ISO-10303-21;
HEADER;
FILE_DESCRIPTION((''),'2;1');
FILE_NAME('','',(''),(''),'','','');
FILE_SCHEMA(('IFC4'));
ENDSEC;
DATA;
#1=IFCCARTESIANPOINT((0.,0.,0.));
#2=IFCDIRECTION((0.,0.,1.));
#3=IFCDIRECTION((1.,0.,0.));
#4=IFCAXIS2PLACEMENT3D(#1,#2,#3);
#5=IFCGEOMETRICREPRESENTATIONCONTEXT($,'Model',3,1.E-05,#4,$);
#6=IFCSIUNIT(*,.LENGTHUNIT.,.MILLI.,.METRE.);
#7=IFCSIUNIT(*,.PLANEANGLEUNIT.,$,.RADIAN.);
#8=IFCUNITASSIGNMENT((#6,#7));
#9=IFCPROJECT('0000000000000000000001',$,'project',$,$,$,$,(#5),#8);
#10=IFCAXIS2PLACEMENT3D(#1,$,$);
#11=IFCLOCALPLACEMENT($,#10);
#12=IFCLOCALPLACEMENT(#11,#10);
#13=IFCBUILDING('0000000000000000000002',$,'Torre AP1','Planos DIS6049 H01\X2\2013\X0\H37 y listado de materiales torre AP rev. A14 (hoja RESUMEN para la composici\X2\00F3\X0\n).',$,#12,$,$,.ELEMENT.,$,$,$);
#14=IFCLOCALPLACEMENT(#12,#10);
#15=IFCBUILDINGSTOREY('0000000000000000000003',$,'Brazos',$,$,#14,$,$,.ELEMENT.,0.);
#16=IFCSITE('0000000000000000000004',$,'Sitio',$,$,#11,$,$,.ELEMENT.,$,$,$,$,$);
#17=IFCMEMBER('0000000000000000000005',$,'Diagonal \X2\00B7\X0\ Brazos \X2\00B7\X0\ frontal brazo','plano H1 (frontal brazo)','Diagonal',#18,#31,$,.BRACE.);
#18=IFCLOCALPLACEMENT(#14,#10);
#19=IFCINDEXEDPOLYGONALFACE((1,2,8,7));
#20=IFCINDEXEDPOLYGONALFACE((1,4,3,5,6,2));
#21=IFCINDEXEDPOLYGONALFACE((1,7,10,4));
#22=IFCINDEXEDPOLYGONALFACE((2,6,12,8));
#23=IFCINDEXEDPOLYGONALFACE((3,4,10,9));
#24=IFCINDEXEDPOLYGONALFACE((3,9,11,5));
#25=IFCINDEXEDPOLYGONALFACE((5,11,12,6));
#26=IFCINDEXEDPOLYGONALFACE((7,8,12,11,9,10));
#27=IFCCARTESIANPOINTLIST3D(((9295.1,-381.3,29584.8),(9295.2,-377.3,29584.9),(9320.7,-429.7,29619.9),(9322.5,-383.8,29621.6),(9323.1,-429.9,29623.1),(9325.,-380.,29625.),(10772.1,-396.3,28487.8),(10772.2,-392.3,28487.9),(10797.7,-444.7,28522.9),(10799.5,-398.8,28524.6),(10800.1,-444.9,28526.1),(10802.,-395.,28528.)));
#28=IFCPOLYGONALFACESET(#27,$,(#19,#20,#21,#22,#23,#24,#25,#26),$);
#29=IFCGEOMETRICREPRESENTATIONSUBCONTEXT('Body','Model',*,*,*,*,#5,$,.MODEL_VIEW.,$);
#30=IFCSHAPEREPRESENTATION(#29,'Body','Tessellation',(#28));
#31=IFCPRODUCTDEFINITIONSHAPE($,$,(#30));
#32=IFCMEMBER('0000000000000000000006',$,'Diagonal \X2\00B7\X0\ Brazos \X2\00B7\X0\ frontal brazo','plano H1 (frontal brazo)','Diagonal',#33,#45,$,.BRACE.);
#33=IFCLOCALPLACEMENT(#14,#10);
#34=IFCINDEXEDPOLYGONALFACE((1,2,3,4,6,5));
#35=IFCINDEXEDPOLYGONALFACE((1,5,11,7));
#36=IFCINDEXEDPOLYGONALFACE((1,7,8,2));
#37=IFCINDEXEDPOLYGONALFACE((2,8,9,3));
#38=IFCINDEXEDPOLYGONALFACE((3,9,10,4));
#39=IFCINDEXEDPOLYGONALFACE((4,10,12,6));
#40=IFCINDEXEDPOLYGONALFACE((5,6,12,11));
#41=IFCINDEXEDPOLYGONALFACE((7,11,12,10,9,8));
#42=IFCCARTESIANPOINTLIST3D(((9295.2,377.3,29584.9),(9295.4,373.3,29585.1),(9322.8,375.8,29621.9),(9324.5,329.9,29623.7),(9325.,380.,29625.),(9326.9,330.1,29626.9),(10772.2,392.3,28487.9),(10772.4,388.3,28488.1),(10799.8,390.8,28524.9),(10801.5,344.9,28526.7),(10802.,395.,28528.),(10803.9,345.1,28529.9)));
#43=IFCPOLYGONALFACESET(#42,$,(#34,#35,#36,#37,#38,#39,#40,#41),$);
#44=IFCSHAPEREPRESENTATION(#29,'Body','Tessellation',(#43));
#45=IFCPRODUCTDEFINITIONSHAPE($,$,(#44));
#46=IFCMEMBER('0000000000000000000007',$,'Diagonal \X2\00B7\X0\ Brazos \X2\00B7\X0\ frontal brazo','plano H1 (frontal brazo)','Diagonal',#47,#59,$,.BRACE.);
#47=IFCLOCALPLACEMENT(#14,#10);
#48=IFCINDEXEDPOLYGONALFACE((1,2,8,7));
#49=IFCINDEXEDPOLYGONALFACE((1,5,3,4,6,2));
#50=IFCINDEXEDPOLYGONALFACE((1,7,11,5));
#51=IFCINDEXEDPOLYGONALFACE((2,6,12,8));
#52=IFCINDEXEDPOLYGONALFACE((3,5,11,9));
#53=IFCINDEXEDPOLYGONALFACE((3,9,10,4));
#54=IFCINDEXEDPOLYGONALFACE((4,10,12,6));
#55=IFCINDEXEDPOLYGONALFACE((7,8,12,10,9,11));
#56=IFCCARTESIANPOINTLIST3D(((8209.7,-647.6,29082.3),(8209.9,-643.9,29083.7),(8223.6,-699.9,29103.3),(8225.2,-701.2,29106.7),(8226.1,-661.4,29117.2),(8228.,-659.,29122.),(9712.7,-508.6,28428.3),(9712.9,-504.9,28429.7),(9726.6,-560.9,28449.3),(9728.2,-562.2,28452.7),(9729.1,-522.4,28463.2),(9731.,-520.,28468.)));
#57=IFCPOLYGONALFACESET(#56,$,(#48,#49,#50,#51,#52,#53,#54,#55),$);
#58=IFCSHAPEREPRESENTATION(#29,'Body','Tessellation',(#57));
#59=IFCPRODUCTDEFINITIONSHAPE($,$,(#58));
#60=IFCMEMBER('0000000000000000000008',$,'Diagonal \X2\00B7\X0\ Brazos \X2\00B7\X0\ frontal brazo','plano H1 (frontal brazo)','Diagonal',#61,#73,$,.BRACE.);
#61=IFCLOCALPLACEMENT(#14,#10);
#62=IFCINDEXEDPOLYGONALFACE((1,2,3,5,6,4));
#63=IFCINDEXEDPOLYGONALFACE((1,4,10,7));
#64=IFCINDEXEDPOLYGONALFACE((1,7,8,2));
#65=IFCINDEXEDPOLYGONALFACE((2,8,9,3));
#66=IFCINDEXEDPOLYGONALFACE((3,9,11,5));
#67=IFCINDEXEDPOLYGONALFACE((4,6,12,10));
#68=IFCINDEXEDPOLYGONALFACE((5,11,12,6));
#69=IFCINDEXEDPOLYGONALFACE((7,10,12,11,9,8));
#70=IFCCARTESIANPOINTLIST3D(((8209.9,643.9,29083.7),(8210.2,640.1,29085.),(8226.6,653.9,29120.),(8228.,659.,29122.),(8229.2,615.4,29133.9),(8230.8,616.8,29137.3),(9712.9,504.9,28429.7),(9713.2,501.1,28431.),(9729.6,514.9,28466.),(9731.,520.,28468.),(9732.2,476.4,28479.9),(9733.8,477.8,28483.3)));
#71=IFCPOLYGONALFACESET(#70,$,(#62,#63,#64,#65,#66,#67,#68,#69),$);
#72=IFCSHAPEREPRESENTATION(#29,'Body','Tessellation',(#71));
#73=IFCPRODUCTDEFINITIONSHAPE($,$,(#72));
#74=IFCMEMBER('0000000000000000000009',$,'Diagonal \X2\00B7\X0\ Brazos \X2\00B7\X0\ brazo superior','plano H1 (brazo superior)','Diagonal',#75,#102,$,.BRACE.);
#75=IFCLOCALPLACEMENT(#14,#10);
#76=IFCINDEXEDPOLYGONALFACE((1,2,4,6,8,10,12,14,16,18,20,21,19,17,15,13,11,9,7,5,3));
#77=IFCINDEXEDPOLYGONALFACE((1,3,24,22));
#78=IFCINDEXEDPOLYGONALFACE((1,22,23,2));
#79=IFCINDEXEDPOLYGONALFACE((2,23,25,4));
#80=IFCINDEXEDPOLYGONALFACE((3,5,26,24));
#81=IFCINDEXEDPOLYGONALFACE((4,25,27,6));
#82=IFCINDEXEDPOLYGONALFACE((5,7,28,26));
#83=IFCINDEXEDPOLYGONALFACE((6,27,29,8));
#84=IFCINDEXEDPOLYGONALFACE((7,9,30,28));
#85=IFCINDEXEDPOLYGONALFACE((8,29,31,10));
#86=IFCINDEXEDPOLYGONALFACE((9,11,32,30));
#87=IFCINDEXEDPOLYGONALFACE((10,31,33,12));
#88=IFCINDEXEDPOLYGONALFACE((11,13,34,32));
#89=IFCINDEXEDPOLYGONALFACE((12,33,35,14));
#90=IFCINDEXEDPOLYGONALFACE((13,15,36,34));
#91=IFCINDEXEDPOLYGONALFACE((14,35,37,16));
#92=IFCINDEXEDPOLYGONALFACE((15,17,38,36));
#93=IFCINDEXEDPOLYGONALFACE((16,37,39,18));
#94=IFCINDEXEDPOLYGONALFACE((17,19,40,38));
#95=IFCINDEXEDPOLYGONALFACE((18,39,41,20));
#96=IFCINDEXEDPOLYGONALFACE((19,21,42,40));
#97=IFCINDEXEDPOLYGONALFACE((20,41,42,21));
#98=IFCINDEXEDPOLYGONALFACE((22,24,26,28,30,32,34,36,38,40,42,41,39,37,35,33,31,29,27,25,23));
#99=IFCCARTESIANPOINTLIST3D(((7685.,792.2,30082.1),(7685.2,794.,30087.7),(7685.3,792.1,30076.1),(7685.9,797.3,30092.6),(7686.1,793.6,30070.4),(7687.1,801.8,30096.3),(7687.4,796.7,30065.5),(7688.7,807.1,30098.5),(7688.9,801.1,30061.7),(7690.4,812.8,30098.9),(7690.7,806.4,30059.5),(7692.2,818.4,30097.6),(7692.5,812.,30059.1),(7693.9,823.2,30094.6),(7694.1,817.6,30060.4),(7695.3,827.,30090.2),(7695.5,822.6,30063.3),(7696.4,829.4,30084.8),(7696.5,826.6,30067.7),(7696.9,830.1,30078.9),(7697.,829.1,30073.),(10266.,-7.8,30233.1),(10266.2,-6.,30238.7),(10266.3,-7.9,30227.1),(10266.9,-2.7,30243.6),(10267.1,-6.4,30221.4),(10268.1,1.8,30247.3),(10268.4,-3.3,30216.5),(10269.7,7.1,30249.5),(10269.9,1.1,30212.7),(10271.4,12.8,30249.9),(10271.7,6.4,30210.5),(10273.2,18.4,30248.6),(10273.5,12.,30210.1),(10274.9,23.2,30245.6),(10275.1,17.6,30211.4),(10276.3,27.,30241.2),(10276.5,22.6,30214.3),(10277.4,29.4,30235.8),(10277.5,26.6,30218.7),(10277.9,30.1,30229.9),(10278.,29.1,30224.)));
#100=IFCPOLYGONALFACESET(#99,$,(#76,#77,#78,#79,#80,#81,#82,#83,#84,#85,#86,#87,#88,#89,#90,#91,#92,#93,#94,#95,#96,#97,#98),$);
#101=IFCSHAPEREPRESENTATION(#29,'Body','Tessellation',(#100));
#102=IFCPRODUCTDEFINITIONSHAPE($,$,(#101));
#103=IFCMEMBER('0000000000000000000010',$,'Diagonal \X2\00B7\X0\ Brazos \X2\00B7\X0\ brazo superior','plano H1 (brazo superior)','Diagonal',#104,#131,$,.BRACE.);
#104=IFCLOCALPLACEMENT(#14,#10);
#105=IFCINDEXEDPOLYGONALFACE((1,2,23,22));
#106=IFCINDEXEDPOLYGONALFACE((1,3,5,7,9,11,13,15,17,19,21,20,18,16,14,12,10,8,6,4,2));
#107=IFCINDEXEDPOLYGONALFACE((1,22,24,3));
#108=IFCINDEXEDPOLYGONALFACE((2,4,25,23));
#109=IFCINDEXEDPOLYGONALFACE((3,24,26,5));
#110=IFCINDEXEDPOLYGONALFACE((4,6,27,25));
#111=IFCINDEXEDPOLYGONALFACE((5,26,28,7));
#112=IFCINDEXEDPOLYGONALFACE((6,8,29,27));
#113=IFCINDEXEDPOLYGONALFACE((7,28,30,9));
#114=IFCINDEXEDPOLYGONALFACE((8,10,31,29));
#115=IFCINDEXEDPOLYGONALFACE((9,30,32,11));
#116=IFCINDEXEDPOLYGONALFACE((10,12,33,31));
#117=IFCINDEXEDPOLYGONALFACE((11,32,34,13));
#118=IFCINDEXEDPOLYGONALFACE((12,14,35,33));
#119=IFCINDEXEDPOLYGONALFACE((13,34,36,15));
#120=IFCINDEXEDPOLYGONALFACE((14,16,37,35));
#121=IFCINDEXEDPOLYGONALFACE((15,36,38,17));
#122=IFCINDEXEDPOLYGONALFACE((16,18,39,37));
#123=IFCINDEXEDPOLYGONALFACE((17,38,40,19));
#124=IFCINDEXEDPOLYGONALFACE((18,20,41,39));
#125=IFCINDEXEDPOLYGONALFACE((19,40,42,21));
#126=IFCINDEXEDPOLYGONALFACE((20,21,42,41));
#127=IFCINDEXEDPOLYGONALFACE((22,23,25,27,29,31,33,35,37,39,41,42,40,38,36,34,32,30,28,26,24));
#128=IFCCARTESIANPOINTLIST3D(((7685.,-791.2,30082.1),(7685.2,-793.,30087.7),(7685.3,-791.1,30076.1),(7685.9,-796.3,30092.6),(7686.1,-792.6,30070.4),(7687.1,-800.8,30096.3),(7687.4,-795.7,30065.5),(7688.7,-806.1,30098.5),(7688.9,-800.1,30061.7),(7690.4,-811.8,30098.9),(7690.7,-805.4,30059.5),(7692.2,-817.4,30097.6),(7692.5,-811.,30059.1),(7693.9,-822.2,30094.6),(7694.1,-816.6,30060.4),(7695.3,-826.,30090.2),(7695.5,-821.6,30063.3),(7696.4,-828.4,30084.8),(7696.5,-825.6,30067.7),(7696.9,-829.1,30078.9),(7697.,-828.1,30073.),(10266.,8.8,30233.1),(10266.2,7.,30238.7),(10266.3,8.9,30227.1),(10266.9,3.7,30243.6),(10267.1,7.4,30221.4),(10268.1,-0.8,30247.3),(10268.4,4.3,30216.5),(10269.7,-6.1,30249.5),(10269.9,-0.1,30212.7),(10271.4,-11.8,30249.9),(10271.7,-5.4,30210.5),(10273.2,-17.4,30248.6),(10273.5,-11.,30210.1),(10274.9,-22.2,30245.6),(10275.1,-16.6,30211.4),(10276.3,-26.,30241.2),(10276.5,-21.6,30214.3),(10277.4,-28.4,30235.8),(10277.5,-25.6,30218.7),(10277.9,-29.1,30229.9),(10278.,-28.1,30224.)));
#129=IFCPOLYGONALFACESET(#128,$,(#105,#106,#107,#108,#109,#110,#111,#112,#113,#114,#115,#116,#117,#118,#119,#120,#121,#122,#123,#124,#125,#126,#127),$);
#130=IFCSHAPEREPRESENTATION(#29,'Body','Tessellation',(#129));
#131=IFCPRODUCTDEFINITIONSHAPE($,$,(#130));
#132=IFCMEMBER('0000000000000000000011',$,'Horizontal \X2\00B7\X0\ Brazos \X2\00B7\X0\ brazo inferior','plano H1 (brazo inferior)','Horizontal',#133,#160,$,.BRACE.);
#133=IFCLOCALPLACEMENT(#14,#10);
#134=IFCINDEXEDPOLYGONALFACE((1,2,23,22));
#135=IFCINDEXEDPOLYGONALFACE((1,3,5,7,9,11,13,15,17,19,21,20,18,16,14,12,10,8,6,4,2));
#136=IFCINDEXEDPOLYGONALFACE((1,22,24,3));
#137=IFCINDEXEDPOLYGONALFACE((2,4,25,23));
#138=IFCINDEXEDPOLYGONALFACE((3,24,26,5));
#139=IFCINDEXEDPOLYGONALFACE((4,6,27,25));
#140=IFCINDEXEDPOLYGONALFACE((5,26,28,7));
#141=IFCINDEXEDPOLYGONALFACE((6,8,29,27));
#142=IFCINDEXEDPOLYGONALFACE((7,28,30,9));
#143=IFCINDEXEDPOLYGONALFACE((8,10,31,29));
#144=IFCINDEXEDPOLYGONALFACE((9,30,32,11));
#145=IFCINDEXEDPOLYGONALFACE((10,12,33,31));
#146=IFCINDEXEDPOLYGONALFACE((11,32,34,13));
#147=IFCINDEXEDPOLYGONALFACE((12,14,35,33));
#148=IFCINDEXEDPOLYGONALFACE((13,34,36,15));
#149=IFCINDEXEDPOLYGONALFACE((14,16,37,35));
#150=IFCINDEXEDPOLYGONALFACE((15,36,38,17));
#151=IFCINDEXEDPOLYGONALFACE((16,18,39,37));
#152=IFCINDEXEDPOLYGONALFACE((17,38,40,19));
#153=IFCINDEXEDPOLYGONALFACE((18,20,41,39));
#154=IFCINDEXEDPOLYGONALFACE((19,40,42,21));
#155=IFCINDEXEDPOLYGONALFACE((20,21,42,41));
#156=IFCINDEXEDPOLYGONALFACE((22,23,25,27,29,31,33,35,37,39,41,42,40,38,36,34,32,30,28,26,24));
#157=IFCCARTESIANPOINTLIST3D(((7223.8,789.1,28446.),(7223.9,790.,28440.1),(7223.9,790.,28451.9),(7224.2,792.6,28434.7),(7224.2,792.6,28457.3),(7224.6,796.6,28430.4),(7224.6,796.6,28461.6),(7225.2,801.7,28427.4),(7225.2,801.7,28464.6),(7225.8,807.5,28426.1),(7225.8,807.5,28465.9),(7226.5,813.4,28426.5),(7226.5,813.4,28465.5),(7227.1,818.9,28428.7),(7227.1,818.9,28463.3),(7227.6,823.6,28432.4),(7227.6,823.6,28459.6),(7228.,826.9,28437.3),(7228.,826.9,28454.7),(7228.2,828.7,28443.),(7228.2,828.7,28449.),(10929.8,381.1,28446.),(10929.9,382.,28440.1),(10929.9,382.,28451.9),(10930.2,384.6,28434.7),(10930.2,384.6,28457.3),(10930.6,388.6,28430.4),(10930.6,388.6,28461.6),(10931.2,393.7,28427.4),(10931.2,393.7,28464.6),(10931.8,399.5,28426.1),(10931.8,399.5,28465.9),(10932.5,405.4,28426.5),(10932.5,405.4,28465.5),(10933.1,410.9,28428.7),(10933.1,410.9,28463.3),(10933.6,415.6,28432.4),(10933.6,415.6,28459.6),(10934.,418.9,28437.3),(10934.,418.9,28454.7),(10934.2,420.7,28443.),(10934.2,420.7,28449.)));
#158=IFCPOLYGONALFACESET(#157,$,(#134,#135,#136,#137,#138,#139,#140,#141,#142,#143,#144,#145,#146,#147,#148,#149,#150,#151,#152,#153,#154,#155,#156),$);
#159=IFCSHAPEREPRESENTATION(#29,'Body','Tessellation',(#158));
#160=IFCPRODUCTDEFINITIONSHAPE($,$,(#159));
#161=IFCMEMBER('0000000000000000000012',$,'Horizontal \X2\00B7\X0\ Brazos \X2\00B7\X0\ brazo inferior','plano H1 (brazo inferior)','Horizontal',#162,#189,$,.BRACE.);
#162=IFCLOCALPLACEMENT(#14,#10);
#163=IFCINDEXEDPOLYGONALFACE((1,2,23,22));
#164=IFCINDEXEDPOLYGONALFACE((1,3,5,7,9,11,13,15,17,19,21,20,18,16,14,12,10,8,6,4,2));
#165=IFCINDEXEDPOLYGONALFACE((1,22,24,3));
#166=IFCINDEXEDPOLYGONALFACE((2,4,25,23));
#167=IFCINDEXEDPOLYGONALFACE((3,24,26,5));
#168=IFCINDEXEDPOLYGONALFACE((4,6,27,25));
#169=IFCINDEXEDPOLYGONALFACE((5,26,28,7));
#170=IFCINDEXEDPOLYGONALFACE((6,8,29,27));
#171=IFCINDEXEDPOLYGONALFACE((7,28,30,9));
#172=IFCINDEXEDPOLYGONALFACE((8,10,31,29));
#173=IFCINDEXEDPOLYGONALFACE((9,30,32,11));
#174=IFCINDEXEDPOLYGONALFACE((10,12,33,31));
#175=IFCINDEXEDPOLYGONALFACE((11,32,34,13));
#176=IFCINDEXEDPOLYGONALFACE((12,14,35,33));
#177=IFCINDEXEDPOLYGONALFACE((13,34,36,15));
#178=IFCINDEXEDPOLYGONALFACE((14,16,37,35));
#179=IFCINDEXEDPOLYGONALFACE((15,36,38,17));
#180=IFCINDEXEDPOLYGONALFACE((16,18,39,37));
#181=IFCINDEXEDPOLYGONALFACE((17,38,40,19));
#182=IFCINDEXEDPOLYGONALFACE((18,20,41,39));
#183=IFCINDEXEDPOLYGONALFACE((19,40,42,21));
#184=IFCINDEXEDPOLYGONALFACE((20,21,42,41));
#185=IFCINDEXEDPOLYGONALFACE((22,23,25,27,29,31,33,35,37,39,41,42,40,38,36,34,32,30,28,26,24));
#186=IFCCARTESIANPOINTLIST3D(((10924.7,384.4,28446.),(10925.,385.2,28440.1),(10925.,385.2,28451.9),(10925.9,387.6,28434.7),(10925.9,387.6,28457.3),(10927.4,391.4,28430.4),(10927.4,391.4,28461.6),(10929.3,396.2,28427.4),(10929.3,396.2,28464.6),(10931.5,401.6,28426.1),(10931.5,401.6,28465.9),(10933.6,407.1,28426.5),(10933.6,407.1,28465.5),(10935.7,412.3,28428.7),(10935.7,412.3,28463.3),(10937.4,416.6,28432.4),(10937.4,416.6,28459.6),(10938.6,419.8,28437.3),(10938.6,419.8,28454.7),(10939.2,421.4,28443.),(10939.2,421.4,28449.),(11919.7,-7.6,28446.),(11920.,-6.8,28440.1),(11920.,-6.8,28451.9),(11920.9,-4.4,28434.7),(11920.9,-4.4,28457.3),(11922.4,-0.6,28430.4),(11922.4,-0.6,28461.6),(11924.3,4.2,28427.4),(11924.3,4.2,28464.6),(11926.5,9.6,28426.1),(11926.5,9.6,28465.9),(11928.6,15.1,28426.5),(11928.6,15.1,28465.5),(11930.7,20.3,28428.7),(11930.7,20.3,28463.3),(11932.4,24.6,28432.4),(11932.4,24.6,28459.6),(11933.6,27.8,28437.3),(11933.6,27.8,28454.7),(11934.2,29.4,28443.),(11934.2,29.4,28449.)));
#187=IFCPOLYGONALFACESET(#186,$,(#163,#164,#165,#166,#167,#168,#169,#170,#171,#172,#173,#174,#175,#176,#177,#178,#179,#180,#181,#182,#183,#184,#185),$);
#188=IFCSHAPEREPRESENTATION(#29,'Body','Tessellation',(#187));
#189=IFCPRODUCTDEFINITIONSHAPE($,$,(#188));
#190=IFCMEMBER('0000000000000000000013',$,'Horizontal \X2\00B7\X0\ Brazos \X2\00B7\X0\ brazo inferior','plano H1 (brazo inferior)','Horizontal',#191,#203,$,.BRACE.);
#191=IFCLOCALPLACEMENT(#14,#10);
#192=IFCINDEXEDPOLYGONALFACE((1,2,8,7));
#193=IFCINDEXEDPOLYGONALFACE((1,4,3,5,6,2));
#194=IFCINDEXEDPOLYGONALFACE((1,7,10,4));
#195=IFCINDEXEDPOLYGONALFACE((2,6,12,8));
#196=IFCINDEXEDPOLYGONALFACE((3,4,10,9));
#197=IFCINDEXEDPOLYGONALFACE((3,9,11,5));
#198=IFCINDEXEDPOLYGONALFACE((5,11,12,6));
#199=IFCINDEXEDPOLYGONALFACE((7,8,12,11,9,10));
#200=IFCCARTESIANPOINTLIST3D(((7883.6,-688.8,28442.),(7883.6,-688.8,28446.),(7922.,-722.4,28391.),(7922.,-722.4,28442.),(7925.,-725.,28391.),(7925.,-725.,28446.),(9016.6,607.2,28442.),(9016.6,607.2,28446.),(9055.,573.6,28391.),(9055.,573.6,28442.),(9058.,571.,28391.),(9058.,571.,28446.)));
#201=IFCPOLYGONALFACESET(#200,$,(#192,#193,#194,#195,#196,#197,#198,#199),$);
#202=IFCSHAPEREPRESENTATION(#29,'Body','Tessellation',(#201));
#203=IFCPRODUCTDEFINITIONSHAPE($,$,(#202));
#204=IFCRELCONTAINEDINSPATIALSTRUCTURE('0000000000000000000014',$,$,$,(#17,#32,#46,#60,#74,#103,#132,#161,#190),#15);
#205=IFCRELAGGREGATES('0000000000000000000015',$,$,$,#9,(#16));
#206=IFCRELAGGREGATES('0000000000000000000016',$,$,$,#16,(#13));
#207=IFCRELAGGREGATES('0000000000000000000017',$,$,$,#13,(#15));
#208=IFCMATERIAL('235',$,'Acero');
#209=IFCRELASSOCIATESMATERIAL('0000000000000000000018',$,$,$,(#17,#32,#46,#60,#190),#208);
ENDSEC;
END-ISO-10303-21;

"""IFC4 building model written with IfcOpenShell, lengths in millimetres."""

from ifc_helpers import new_model, si_unit, frame, frame_2d, origin, origin_with_axes, place, context, subcontext, project, spatial, circle, l_section, extrude, material, element, save


model = new_model("IFC4")

# Units and contexts
model_context = context("Model", 3, precision=1e-05, world=origin_with_axes())
body_context = subcontext(model_context, "Body", "Model", "MODEL_VIEW")
ifc_project = project(units=[si_unit("LENGTHUNIT", "METRE", prefix="MILLI"), si_unit("PLANEANGLEUNIT", "RADIAN")], contexts=[model_context])

# Site, building, storey
site_placement = place(None, origin())
site = spatial("IfcSite", under=ifc_project, at=site_placement, Name="Sitio", CompositionType="ELEMENT")
building_placement = place(site_placement, origin())
building = spatial("IfcBuilding", under=site, at=building_placement, Name="Torre AP1", Description="Planos DIS6049 H01–H37 y listado de materiales torre AP rev. A14 (hoja RESUMEN para la composición).", CompositionType="ELEMENT")
storey_placement = place(building_placement, origin())
storey = spatial("IfcBuildingStorey", under=building, at=storey_placement, Name="Brazos", CompositionType="ELEMENT", Elevation=0.0)

# Members
ifc_material_1 = material(Name="235", Category="Acero")
for number, where, z_axis, x_axis, name in (
    (1, (10802.0, -395.0, 28528.0), (-0.802769, 0.008153, 0.596234), (-0.595049, 0.053521, -0.801905), "Diagonal · Brazos · frontal brazo"),
    (2, (10802.0, 395.0, 28528.0), (-0.802769, -0.008153, 0.596234), (-0.595049, -0.053521, -0.801905), "Diagonal · Brazos · frontal brazo"),
):
    element("IfcMember", number, at=place(storey_placement, frame(where, z_axis=z_axis, x_axis=x_axis)), inside=storey, material=ifc_material_1, Name=name, Description="plano H1 (frontal brazo)", ObjectType="Diagonal", PredefinedType="BRACE", context=body_context, shape_type="SweptSolid", body=[
        extrude(l_section(Depth=50.0, Width=50.0, Thickness=4.0, at=frame_2d((25.0, 25.0))), None, (0.0, 0.0, 1.0), 1839.9),
    ])
for number, where, z_axis, x_axis, name in (
    (3, (9731.0, -520.0, 28468.0), (-0.913674, -0.084498, 0.397567), (-0.401755, 0.335963, -0.851893), "Diagonal · Brazos · frontal brazo"),
    (4, (9731.0, 520.0, 28468.0), (-0.913674, 0.084498, 0.397567), (-0.401755, -0.335963, -0.851893), "Diagonal · Brazos · frontal brazo"),
):
    element("IfcMember", number, at=place(storey_placement, frame(where, z_axis=z_axis, x_axis=x_axis)), inside=storey, material=ifc_material_1, Name=name, Description="plano H1 (frontal brazo)", ObjectType="Diagonal", PredefinedType="BRACE", context=body_context, shape_type="SweptSolid", body=[
        extrude(l_section(Depth=45.0, Width=45.0, Thickness=4.0, at=frame_2d((22.5, 22.5))), None, (0.0, 0.0, 1.0), 1645.0),
    ])
for number, where, z_axis, x_axis, name in (
    (5, (7691.0, 811.0, 30079.0), (0.953681, -0.2956, 0.055795), (-0.300728, -0.941427, 0.152572), "Diagonal · Brazos · brazo superior"),
    (6, (10272.0, -10.0, 30230.0), (-0.953681, -0.2956, -0.055795), (-0.300729, 0.941418, 0.152624), "Diagonal · Brazos · brazo superior"),
):
    element("IfcMember", number, at=place(storey_placement, frame(where, z_axis=z_axis, x_axis=x_axis)), inside=storey, Name=name, Description="plano H1 (brazo superior)", ObjectType="Diagonal", PredefinedType="BRACE", context=body_context, shape_type="SweptSolid", body=[
        extrude(circle(Radius=20.0), None, (0.0, 0.0, 1.0), 2706.4),
    ])
member_1_placement = place(storey_placement, frame((7226.0, 809.0, 28446.0), z_axis=(0.993994, -0.109431, 0.0), x_axis=(-0.109431, -0.993994, 0.0)))
element("IfcMember", 7, at=member_1_placement, inside=storey, Name="Horizontal · Brazos · brazo inferior", Description="plano H1 (brazo inferior)", ObjectType="Horizontal", PredefinedType="BRACE", context=body_context, shape_type="SweptSolid", body=[
    extrude(circle(Radius=20.0), None, (0.0, 0.0, 1.0), 3728.4),
])
member_2_placement = place(storey_placement, frame((10932.0, 403.0, 28446.0), z_axis=(0.930399, -0.366549, 0.0), x_axis=(-0.366549, -0.930399, 0.0)))
element("IfcMember", 8, at=member_2_placement, inside=storey, Name="Horizontal · Brazos · brazo inferior", Description="plano H1 (brazo inferior)", ObjectType="Horizontal", PredefinedType="BRACE", context=body_context, shape_type="SweptSolid", body=[
    extrude(circle(Radius=20.0), None, (0.0, 0.0, 1.0), 1069.4),
])
member_3_placement = place(storey_placement, frame((9058.0, 571.0, 28446.0), z_axis=(-0.658176, -0.752865, 0.0), x_axis=(-0.752865, 0.658176, 0.0)))
element("IfcMember", 9, at=member_3_placement, inside=storey, material=ifc_material_1, Name="Horizontal · Brazos · brazo inferior", Description="plano H1 (brazo inferior)", ObjectType="Horizontal", PredefinedType="BRACE", context=body_context, shape_type="SweptSolid", body=[
    extrude(l_section(Depth=55.0, Width=55.0, Thickness=4.0, at=frame_2d((27.5, 27.5))), None, (0.0, 0.0, 1.0), 1721.4),
])

save(model, "model.ifc")
